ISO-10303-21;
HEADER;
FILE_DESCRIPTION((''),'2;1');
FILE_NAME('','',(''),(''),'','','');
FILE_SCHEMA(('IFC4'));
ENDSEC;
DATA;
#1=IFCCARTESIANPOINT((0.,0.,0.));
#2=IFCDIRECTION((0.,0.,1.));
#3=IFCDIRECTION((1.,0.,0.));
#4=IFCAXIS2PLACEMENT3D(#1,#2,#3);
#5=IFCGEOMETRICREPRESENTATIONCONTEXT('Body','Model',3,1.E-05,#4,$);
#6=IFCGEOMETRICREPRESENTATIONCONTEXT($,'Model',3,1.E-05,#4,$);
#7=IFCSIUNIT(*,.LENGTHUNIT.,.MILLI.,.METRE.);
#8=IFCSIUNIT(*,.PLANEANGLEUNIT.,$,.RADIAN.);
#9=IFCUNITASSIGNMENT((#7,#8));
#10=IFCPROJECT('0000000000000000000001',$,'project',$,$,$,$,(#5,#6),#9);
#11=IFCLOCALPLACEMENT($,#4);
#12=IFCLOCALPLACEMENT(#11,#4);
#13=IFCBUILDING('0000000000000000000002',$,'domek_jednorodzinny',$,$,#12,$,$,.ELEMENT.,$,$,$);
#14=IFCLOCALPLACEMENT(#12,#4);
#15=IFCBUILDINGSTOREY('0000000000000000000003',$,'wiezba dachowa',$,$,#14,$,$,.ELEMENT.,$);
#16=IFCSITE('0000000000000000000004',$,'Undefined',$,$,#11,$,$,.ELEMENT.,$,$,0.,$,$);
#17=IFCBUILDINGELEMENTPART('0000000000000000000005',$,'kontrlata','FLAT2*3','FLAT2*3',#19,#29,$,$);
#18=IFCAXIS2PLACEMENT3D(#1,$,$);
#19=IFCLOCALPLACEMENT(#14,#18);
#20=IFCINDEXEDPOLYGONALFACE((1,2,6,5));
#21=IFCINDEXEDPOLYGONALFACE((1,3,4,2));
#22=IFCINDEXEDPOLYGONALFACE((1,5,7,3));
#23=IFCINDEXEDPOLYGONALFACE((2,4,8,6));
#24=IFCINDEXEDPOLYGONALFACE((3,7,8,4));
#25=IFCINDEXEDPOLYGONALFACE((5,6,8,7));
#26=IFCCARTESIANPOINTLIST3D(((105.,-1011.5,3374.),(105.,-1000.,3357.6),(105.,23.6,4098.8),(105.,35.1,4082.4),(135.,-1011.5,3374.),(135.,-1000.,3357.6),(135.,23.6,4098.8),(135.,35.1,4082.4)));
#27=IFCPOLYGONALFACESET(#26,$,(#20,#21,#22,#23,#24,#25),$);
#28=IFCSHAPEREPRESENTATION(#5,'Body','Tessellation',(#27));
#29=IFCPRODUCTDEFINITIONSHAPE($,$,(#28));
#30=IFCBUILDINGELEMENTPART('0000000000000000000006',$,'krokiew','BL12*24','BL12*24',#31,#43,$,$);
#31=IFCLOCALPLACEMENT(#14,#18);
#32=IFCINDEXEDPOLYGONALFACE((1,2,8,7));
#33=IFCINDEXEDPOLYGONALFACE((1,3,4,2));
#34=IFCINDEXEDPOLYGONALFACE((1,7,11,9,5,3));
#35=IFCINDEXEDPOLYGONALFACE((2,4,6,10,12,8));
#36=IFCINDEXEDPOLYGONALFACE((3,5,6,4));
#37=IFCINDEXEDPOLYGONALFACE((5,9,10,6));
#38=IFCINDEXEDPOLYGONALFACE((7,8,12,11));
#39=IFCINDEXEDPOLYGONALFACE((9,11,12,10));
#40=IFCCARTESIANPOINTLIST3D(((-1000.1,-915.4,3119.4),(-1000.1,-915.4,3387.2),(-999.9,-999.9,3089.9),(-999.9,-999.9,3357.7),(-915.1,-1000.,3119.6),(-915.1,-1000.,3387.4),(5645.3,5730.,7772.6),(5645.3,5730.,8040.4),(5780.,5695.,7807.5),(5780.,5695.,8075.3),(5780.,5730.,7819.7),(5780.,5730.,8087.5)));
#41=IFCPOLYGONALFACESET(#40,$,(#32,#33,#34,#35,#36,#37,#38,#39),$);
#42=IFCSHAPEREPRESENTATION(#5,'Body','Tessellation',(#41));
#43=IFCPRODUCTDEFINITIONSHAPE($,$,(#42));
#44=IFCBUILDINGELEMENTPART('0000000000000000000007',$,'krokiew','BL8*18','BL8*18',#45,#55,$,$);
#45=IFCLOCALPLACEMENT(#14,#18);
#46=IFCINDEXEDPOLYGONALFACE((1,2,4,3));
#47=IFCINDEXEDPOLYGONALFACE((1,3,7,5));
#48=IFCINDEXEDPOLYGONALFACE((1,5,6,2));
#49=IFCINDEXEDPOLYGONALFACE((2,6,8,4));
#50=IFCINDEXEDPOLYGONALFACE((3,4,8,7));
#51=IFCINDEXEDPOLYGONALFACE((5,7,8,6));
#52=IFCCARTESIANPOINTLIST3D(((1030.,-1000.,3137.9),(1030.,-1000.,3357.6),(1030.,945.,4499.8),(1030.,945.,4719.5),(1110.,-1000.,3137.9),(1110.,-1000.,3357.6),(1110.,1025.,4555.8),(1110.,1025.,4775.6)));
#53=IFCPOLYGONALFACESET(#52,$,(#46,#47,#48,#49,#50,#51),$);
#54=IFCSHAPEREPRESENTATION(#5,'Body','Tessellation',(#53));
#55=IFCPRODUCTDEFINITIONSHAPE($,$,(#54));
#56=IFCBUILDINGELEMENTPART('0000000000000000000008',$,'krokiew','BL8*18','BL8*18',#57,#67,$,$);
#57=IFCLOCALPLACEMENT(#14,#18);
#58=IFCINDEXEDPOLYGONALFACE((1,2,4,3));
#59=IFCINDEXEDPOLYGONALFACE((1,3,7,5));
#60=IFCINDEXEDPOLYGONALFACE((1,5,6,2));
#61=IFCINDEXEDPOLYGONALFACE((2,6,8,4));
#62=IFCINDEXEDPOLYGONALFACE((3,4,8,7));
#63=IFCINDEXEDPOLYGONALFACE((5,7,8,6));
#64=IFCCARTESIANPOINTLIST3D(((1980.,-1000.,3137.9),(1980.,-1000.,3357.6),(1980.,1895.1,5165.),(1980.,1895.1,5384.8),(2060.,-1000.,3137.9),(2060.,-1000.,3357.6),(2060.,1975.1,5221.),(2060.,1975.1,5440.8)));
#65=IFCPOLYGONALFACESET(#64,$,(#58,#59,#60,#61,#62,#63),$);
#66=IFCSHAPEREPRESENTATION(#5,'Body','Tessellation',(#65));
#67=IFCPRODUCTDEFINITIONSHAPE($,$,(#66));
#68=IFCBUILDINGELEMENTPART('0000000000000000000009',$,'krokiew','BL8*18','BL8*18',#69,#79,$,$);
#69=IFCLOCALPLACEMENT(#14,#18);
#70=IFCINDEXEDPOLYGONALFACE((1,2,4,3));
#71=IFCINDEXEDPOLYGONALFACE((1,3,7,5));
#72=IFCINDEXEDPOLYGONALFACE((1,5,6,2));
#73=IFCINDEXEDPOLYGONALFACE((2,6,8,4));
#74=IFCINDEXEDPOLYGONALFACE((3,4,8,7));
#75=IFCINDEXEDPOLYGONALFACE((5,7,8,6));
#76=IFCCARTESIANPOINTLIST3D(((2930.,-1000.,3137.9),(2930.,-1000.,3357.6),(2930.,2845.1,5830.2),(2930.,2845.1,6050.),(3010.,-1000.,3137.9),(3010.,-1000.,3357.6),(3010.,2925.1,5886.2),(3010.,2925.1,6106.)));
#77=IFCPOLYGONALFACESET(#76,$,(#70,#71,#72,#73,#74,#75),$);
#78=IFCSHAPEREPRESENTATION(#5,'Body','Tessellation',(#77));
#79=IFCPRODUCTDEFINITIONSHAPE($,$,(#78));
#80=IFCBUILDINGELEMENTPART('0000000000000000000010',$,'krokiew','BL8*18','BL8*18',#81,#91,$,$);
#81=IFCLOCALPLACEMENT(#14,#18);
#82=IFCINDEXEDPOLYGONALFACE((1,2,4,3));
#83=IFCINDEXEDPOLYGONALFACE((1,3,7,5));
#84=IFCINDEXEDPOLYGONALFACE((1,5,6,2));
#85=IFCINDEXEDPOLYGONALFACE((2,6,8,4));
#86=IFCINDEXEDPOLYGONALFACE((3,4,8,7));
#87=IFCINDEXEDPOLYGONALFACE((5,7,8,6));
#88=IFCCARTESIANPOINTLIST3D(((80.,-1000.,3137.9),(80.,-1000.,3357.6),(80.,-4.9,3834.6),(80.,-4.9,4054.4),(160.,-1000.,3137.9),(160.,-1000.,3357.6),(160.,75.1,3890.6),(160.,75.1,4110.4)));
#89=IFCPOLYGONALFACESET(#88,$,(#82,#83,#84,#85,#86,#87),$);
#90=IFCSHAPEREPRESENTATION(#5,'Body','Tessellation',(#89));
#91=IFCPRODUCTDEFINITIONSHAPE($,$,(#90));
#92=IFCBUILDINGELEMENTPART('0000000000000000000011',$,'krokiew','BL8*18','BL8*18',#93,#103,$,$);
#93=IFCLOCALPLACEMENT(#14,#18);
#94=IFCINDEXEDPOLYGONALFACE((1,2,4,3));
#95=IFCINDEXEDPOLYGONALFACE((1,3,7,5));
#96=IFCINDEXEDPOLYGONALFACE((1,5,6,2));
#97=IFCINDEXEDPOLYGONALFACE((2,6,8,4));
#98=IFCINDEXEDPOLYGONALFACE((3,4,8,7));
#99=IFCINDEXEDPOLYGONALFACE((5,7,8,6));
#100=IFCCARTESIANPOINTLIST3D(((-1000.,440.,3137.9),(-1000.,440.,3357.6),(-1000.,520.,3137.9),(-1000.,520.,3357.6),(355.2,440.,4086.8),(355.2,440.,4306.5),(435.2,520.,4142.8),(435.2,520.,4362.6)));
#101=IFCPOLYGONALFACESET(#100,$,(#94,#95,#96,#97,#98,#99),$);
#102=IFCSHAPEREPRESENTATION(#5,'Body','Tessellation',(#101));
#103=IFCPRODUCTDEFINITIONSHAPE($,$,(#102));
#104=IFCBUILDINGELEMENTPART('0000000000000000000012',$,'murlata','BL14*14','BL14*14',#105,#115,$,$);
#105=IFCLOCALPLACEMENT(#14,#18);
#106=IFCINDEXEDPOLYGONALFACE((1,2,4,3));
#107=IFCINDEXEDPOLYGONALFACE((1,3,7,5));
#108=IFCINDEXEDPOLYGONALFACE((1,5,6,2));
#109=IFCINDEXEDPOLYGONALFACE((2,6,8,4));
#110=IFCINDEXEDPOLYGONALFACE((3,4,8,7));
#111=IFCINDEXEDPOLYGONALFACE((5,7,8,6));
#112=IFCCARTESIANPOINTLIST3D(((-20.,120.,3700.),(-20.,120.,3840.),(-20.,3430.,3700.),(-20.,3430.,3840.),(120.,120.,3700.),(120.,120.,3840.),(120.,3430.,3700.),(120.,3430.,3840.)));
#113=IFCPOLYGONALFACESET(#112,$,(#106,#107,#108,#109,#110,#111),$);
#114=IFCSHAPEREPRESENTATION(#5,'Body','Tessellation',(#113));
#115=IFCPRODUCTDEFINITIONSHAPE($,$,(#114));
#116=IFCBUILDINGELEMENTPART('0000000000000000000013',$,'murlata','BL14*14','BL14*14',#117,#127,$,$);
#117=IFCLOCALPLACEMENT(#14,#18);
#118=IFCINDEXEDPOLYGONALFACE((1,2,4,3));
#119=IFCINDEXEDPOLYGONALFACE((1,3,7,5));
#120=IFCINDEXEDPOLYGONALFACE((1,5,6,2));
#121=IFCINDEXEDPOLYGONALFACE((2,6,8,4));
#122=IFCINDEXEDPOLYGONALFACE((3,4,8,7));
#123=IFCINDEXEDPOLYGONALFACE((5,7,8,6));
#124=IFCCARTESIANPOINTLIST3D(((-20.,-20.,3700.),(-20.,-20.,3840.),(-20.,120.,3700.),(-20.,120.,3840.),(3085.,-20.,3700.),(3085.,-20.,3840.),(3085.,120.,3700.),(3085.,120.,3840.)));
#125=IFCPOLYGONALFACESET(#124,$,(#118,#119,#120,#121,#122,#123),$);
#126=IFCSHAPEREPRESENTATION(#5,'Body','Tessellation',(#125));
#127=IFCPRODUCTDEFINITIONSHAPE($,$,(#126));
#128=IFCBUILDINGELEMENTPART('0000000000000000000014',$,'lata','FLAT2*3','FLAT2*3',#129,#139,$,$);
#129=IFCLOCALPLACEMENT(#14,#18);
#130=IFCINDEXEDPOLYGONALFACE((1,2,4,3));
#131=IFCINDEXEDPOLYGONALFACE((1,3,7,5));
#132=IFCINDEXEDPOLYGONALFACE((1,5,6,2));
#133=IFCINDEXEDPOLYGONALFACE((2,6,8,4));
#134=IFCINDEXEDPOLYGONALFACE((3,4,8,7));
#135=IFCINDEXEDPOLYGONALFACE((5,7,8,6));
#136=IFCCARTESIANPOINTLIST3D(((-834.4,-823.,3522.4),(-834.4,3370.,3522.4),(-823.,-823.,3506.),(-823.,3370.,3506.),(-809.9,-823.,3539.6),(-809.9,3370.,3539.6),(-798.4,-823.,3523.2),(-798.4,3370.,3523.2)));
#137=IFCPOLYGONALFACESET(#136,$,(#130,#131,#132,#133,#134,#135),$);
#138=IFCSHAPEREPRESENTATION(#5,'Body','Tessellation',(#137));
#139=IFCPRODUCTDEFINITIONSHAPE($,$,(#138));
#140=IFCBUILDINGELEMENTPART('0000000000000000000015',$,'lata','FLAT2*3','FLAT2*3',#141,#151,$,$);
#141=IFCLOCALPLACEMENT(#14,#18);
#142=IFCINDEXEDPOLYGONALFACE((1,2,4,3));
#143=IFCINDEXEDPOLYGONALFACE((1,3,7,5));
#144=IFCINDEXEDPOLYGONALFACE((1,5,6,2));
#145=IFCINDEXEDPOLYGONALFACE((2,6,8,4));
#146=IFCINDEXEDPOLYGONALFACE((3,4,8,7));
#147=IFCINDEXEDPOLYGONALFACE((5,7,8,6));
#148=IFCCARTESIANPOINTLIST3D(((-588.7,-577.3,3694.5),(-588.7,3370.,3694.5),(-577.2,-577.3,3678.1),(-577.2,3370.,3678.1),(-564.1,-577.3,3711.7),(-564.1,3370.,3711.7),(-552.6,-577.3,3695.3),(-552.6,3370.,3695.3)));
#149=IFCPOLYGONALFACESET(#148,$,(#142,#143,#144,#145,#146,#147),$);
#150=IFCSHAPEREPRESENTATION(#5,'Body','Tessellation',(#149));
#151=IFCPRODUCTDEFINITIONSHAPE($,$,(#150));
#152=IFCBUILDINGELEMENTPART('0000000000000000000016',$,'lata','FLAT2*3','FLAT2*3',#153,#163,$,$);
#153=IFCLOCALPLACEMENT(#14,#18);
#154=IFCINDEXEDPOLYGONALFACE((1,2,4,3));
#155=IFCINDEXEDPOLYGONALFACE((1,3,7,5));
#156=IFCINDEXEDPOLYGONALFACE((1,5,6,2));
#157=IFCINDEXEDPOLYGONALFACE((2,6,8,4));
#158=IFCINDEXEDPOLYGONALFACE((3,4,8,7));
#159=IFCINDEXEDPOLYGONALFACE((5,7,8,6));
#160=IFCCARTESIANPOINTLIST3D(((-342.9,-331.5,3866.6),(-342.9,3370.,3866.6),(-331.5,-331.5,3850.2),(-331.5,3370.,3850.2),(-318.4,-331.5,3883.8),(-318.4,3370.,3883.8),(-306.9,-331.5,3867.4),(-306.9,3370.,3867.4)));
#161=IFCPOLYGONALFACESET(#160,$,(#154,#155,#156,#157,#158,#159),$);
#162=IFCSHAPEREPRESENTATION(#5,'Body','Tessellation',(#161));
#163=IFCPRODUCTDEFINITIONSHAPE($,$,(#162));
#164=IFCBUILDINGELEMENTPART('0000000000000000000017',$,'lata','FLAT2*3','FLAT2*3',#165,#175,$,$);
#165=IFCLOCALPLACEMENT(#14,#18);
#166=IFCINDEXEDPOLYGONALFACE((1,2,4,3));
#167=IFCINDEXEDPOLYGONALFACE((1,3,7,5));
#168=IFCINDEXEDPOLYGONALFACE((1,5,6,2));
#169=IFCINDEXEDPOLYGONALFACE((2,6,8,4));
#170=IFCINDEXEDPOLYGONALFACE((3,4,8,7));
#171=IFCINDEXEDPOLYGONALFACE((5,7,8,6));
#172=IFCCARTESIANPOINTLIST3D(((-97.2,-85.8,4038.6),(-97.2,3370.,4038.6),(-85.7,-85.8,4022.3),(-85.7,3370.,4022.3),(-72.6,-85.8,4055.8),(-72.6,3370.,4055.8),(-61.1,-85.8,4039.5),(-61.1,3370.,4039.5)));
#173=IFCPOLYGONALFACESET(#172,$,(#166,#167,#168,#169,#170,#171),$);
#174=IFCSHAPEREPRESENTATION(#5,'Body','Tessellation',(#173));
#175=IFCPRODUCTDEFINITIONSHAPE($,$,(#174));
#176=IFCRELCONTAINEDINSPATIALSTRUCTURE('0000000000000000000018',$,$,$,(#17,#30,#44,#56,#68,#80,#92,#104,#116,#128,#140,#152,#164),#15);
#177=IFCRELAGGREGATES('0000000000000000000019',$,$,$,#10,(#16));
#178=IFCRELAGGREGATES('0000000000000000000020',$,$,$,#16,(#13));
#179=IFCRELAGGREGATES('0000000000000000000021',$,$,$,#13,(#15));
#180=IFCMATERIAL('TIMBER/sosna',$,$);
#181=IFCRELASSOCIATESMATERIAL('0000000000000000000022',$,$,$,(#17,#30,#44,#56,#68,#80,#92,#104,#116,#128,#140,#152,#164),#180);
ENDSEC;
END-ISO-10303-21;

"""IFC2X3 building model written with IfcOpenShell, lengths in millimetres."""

from ifc_helpers import new_model, si_unit, frame, origin_with_axes, origin_2d_with_axis, place, context, project, spatial, rectangle, extrude, clip, halfspace, material, element, save


model = new_model("IFC2X3")

# Units and contexts
model_context_1 = context("Model", 3, precision=1e-05, world=origin_with_axes(), identifier="Body")
model_context_2 = context("Model", 3, precision=1e-05, world=origin_with_axes())
ifc_project = project(units=[si_unit("LENGTHUNIT", "METRE", prefix="MILLI"), si_unit("PLANEANGLEUNIT", "RADIAN")], contexts=[model_context_1, model_context_2])

# Site, building, storey
site_placement = place(None, origin_with_axes())
site = spatial("IfcSite", under=ifc_project, at=site_placement, Name="Undefined", CompositionType="ELEMENT", RefElevation=0.0)
building_placement = place(site_placement, origin_with_axes())
building = spatial("IfcBuilding", under=site, at=building_placement, Name="domek_jednorodzinny", CompositionType="ELEMENT")
storey_placement = place(building_placement, origin_with_axes())
storey = spatial("IfcBuildingStorey", under=building, at=storey_placement, Name="wiezba dachowa", CompositionType="ELEMENT")

# Building element parts
ifc_material = material(Name="TIMBER/sosna")
building_element_part_1_placement = place(storey_placement, frame((120.0, -1005.7, 3365.8), z_axis=(-1.0, 0.0, 0.0), x_axis=(0.0, 0.819154, 0.573574)))
element("IfcBuildingElementPart", 1, at=building_element_part_1_placement, inside=storey, material=ifc_material, Name="kontrlata", Description="FLAT2*3", ObjectType="FLAT2*3", context=model_context_1, shape_type="SweptSolid", body=[
    extrude(rectangle(XDim=20.0, YDim=30.0, at=origin_2d_with_axis()), frame((1263.6, 0.0, 0.0), z_axis=(-1.0, 0.0, 0.0), x_axis=(0.0, -1.0, 0.0)), (0.0, 0.0, 1.0), 1263.6),
])
building_element_part_2_placement = place(storey_placement, frame((-1088.9, -1089.0, 3161.4), z_axis=(-0.313751, -0.313751, 0.89617), x_axis=(0.633688, 0.633688, 0.443711)))
element("IfcBuildingElementPart", 2, at=building_element_part_2_placement, inside=storey, material=ifc_material, Name="krokiew", Description="BL12*24", ObjectType="BL12*24", context=model_context_1, shape_type="Clipping", body=[
    clip(clip(clip(clip(extrude(rectangle(XDim=120.0, YDim=240.0, at=origin_2d_with_axis()), frame((10920.2, 0.0, 0.0), z_axis=(-1.0, 0.0, 0.0), x_axis=(0.0, -1.0, 0.0)), (0.0, 0.0, 1.0), 10920.2), halfspace(frame((10713.2, -60.0, -120.0), z_axis=(0.63306, -0.707807, -0.31344), x_axis=(0.443711, 0.0, 0.89617)), False)), halfspace(frame((10768.4, -60.0, -120.0), z_axis=(0.633688, 0.707106, -0.313751), x_axis=(0.443711, 0.0, 0.89617)), False)), halfspace(frame((14.3, 60.0, -120.0), z_axis=(-0.634258, -0.70647, 0.314033), x_axis=(0.443711, 0.0, 0.89617)), False)), halfspace(frame((147.7, 60.0, -120.0), z_axis=(-0.635872, 0.704661, 0.314832), x_axis=(0.443711, 0.0, 0.89617)), False)),
])
building_element_part_3_placement = place(storey_placement, frame((1070.0, -1051.6, 3211.6), z_axis=(0.0, -0.573576, 0.819152), x_axis=(0.0, 0.819154, 0.573574)))
element("IfcBuildingElementPart", 3, at=building_element_part_3_placement, inside=storey, material=ifc_material, Name="krokiew", Description="BL8*18", ObjectType="BL8*18", context=model_context_1, shape_type="Clipping", body=[
    clip(clip(extrude(rectangle(XDim=80.0, YDim=180.0, at=origin_2d_with_axis()), frame((2841.8, 0.0, 0.0), z_axis=(-1.0, 0.0, 0.0), x_axis=(0.0, -1.0, 0.0)), (0.0, 0.0, 1.0), 2841.8), halfspace(frame((0.0, 40.0, -90.0), z_axis=(-0.819152, 0.0, 0.573576), x_axis=(0.573578, 0.0, 0.819151)), False)), halfspace(frame((2472.1, -40.0, -90.0), z_axis=(0.579226, 0.707109, -0.405579), x_axis=(0.573578, 0.0, 0.819151)), False)),
])
building_element_part_4_placement = place(storey_placement, frame((2020.0, -1051.6, 3211.6), z_axis=(0.0, -0.573576, 0.819152), x_axis=(0.0, 0.819154, 0.573574)))
element("IfcBuildingElementPart", 4, at=building_element_part_4_placement, inside=storey, material=ifc_material, Name="krokiew", Description="BL8*18", ObjectType="BL8*18", context=model_context_1, shape_type="Clipping", body=[
    clip(clip(extrude(rectangle(XDim=80.0, YDim=180.0, at=origin_2d_with_axis()), frame((4341.8, 0.0, 0.0), z_axis=(-1.0, 0.0, 0.0), x_axis=(0.0, -1.0, 0.0)), (0.0, 0.0, 1.0), 4341.8), halfspace(frame((0.0, 40.0, -90.0), z_axis=(-0.819152, 0.0, 0.573576), x_axis=(0.573578, 0.0, 0.819151)), False)), halfspace(frame((3631.9, -40.0, -90.0), z_axis=(0.579226, 0.707109, -0.405579), x_axis=(0.573578, 0.0, 0.819151)), False)),
])
building_element_part_5_placement = place(storey_placement, frame((2970.0, -1051.6, 3211.6), z_axis=(0.0, -0.573576, 0.819152), x_axis=(0.0, 0.819154, 0.573574)))
element("IfcBuildingElementPart", 5, at=building_element_part_5_placement, inside=storey, material=ifc_material, Name="krokiew", Description="BL8*18", ObjectType="BL8*18", context=model_context_1, shape_type="Clipping", body=[
    clip(clip(extrude(rectangle(XDim=80.0, YDim=180.0, at=origin_2d_with_axis()), frame((8341.8, 0.0, 0.0), z_axis=(-1.0, 0.0, 0.0), x_axis=(0.0, -1.0, 0.0)), (0.0, 0.0, 1.0), 8341.8), halfspace(frame((0.0, 40.0, -90.0), z_axis=(-0.819152, 0.0, 0.573576), x_axis=(0.573578, 0.0, 0.819151)), False)), halfspace(frame((4791.6, -40.0, -90.0), z_axis=(0.579226, 0.707109, -0.405579), x_axis=(0.573578, 0.0, 0.819151)), False)),
])
building_element_part_6_placement = place(storey_placement, frame((120.0, -1051.6, 3211.6), z_axis=(0.0, -0.573576, 0.819152), x_axis=(0.0, 0.819154, 0.573574)))
element("IfcBuildingElementPart", 6, at=building_element_part_6_placement, inside=storey, material=ifc_material, Name="krokiew", Description="BL8*18", ObjectType="BL8*18", context=model_context_1, shape_type="Clipping", body=[
    clip(clip(extrude(rectangle(XDim=80.0, YDim=180.0, at=origin_2d_with_axis()), frame((1841.8, 0.0, 0.0), z_axis=(-1.0, 0.0, 0.0), x_axis=(0.0, -1.0, 0.0)), (0.0, 0.0, 1.0), 1841.8), halfspace(frame((0.0, 40.0, -90.0), z_axis=(-0.819152, 0.0, 0.573576), x_axis=(0.573578, 0.0, 0.819151)), False)), halfspace(frame((1312.4, -40.0, -90.0), z_axis=(0.579226, 0.707109, -0.405579), x_axis=(0.573578, 0.0, 0.819151)), False)),
])
building_element_part_7_placement = place(storey_placement, frame((-1051.6, 480.0, 3211.6), z_axis=(-0.573576, 0.0, 0.819152), x_axis=(0.819152, 0.0, 0.573576)))
element("IfcBuildingElementPart", 7, at=building_element_part_7_placement, inside=storey, material=ifc_material, Name="krokiew", Description="BL8*18", ObjectType="BL8*18", context=model_context_1, shape_type="Clipping", body=[
    clip(clip(extrude(rectangle(XDim=80.0, YDim=180.0, at=origin_2d_with_axis()), frame((2341.8, 0.0, 0.0), z_axis=(-1.0, 0.0, 0.0), x_axis=(0.0, -1.0, 0.0)), (0.0, 0.0, 1.0), 2341.8), halfspace(frame((0.0, 40.0, -90.0), z_axis=(-0.819152, 0.0, 0.573576), x_axis=(0.573578, 0.0, 0.819151)), False)), halfspace(frame((1654.4, -40.0, -90.0), z_axis=(0.578971, -0.70742, -0.4054), x_axis=(0.573578, 0.0, 0.819151)), False)),
])
building_element_part_8_placement = place(storey_placement, frame((50.0, 120.0, 3770.0), z_axis=(0.0, 0.0, 1.0), x_axis=(0.0, 1.0, 0.0)))
element("IfcBuildingElementPart", 8, at=building_element_part_8_placement, inside=storey, material=ifc_material, Name="murlata", Description="BL14*14", ObjectType="BL14*14", context=model_context_1, shape_type="SweptSolid", body=[
    extrude(rectangle(XDim=140.0, YDim=140.0, at=origin_2d_with_axis()), frame((3310.0, 0.0, 0.0), z_axis=(-1.0, 0.0, 0.0), x_axis=(0.0, -1.0, 0.0)), (0.0, 0.0, 1.0), 3310.0),
])
building_element_part_9_placement = place(storey_placement, frame((-20.0, 50.0, 3770.0), z_axis=(0.0, 0.0, 1.0), x_axis=(1.0, 0.0, 0.0)))
element("IfcBuildingElementPart", 9, at=building_element_part_9_placement, inside=storey, material=ifc_material, Name="murlata", Description="BL14*14", ObjectType="BL14*14", context=model_context_1, shape_type="SweptSolid", body=[
    extrude(rectangle(XDim=140.0, YDim=140.0, at=origin_2d_with_axis()), frame((3105.0, 0.0, 0.0), z_axis=(-1.0, 0.0, 0.0), x_axis=(0.0, -1.0, 0.0)), (0.0, 0.0, 1.0), 3105.0),
])
building_element_part_10_placement = place(storey_placement, frame((-816.4, -823.0, 3522.8), z_axis=(0.819152, 0.0, 0.573576), x_axis=(0.0, 1.0, 0.0)))
element("IfcBuildingElementPart", 10, at=building_element_part_10_placement, inside=storey, material=ifc_material, Name="lata", Description="FLAT2*3", ObjectType="FLAT2*3", context=model_context_1, shape_type="SweptSolid", body=[
    extrude(rectangle(XDim=20.0, YDim=30.0, at=origin_2d_with_axis()), frame((4193.0, 0.0, 0.0), z_axis=(-1.0, 0.0, 0.0), x_axis=(0.0, -1.0, 0.0)), (0.0, 0.0, 1.0), 4193.0),
])
building_element_part_11_placement = place(storey_placement, frame((-570.7, -577.3, 3694.9), z_axis=(0.819152, 0.0, 0.573576), x_axis=(0.0, 1.0, 0.0)))
element("IfcBuildingElementPart", 11, at=building_element_part_11_placement, inside=storey, material=ifc_material, Name="lata", Description="FLAT2*3", ObjectType="FLAT2*3", context=model_context_1, shape_type="SweptSolid", body=[
    extrude(rectangle(XDim=20.0, YDim=30.0, at=origin_2d_with_axis()), frame((3947.3, 0.0, 0.0), z_axis=(-1.0, 0.0, 0.0), x_axis=(0.0, -1.0, 0.0)), (0.0, 0.0, 1.0), 3947.3),
])
building_element_part_12_placement = place(storey_placement, frame((-324.9, -331.5, 3867.0), z_axis=(0.819152, 0.0, 0.573576), x_axis=(0.0, 1.0, 0.0)))
element("IfcBuildingElementPart", 12, at=building_element_part_12_placement, inside=storey, material=ifc_material, Name="lata", Description="FLAT2*3", ObjectType="FLAT2*3", context=model_context_1, shape_type="SweptSolid", body=[
    extrude(rectangle(XDim=20.0, YDim=30.0, at=origin_2d_with_axis()), frame((3701.5, 0.0, 0.0), z_axis=(-1.0, 0.0, 0.0), x_axis=(0.0, -1.0, 0.0)), (0.0, 0.0, 1.0), 3701.5),
])
building_element_part_13_placement = place(storey_placement, frame((-79.2, -85.8, 4039.0), z_axis=(0.819152, 0.0, 0.573576), x_axis=(0.0, 1.0, 0.0)))
element("IfcBuildingElementPart", 13, at=building_element_part_13_placement, inside=storey, material=ifc_material, Name="lata", Description="FLAT2*3", ObjectType="FLAT2*3", context=model_context_1, shape_type="SweptSolid", body=[
    extrude(rectangle(XDim=20.0, YDim=30.0, at=origin_2d_with_axis()), frame((3455.8, 0.0, 0.0), z_axis=(-1.0, 0.0, 0.0), x_axis=(0.0, -1.0, 0.0)), (0.0, 0.0, 1.0), 3455.8),
])

save(model, "model.ifc")
